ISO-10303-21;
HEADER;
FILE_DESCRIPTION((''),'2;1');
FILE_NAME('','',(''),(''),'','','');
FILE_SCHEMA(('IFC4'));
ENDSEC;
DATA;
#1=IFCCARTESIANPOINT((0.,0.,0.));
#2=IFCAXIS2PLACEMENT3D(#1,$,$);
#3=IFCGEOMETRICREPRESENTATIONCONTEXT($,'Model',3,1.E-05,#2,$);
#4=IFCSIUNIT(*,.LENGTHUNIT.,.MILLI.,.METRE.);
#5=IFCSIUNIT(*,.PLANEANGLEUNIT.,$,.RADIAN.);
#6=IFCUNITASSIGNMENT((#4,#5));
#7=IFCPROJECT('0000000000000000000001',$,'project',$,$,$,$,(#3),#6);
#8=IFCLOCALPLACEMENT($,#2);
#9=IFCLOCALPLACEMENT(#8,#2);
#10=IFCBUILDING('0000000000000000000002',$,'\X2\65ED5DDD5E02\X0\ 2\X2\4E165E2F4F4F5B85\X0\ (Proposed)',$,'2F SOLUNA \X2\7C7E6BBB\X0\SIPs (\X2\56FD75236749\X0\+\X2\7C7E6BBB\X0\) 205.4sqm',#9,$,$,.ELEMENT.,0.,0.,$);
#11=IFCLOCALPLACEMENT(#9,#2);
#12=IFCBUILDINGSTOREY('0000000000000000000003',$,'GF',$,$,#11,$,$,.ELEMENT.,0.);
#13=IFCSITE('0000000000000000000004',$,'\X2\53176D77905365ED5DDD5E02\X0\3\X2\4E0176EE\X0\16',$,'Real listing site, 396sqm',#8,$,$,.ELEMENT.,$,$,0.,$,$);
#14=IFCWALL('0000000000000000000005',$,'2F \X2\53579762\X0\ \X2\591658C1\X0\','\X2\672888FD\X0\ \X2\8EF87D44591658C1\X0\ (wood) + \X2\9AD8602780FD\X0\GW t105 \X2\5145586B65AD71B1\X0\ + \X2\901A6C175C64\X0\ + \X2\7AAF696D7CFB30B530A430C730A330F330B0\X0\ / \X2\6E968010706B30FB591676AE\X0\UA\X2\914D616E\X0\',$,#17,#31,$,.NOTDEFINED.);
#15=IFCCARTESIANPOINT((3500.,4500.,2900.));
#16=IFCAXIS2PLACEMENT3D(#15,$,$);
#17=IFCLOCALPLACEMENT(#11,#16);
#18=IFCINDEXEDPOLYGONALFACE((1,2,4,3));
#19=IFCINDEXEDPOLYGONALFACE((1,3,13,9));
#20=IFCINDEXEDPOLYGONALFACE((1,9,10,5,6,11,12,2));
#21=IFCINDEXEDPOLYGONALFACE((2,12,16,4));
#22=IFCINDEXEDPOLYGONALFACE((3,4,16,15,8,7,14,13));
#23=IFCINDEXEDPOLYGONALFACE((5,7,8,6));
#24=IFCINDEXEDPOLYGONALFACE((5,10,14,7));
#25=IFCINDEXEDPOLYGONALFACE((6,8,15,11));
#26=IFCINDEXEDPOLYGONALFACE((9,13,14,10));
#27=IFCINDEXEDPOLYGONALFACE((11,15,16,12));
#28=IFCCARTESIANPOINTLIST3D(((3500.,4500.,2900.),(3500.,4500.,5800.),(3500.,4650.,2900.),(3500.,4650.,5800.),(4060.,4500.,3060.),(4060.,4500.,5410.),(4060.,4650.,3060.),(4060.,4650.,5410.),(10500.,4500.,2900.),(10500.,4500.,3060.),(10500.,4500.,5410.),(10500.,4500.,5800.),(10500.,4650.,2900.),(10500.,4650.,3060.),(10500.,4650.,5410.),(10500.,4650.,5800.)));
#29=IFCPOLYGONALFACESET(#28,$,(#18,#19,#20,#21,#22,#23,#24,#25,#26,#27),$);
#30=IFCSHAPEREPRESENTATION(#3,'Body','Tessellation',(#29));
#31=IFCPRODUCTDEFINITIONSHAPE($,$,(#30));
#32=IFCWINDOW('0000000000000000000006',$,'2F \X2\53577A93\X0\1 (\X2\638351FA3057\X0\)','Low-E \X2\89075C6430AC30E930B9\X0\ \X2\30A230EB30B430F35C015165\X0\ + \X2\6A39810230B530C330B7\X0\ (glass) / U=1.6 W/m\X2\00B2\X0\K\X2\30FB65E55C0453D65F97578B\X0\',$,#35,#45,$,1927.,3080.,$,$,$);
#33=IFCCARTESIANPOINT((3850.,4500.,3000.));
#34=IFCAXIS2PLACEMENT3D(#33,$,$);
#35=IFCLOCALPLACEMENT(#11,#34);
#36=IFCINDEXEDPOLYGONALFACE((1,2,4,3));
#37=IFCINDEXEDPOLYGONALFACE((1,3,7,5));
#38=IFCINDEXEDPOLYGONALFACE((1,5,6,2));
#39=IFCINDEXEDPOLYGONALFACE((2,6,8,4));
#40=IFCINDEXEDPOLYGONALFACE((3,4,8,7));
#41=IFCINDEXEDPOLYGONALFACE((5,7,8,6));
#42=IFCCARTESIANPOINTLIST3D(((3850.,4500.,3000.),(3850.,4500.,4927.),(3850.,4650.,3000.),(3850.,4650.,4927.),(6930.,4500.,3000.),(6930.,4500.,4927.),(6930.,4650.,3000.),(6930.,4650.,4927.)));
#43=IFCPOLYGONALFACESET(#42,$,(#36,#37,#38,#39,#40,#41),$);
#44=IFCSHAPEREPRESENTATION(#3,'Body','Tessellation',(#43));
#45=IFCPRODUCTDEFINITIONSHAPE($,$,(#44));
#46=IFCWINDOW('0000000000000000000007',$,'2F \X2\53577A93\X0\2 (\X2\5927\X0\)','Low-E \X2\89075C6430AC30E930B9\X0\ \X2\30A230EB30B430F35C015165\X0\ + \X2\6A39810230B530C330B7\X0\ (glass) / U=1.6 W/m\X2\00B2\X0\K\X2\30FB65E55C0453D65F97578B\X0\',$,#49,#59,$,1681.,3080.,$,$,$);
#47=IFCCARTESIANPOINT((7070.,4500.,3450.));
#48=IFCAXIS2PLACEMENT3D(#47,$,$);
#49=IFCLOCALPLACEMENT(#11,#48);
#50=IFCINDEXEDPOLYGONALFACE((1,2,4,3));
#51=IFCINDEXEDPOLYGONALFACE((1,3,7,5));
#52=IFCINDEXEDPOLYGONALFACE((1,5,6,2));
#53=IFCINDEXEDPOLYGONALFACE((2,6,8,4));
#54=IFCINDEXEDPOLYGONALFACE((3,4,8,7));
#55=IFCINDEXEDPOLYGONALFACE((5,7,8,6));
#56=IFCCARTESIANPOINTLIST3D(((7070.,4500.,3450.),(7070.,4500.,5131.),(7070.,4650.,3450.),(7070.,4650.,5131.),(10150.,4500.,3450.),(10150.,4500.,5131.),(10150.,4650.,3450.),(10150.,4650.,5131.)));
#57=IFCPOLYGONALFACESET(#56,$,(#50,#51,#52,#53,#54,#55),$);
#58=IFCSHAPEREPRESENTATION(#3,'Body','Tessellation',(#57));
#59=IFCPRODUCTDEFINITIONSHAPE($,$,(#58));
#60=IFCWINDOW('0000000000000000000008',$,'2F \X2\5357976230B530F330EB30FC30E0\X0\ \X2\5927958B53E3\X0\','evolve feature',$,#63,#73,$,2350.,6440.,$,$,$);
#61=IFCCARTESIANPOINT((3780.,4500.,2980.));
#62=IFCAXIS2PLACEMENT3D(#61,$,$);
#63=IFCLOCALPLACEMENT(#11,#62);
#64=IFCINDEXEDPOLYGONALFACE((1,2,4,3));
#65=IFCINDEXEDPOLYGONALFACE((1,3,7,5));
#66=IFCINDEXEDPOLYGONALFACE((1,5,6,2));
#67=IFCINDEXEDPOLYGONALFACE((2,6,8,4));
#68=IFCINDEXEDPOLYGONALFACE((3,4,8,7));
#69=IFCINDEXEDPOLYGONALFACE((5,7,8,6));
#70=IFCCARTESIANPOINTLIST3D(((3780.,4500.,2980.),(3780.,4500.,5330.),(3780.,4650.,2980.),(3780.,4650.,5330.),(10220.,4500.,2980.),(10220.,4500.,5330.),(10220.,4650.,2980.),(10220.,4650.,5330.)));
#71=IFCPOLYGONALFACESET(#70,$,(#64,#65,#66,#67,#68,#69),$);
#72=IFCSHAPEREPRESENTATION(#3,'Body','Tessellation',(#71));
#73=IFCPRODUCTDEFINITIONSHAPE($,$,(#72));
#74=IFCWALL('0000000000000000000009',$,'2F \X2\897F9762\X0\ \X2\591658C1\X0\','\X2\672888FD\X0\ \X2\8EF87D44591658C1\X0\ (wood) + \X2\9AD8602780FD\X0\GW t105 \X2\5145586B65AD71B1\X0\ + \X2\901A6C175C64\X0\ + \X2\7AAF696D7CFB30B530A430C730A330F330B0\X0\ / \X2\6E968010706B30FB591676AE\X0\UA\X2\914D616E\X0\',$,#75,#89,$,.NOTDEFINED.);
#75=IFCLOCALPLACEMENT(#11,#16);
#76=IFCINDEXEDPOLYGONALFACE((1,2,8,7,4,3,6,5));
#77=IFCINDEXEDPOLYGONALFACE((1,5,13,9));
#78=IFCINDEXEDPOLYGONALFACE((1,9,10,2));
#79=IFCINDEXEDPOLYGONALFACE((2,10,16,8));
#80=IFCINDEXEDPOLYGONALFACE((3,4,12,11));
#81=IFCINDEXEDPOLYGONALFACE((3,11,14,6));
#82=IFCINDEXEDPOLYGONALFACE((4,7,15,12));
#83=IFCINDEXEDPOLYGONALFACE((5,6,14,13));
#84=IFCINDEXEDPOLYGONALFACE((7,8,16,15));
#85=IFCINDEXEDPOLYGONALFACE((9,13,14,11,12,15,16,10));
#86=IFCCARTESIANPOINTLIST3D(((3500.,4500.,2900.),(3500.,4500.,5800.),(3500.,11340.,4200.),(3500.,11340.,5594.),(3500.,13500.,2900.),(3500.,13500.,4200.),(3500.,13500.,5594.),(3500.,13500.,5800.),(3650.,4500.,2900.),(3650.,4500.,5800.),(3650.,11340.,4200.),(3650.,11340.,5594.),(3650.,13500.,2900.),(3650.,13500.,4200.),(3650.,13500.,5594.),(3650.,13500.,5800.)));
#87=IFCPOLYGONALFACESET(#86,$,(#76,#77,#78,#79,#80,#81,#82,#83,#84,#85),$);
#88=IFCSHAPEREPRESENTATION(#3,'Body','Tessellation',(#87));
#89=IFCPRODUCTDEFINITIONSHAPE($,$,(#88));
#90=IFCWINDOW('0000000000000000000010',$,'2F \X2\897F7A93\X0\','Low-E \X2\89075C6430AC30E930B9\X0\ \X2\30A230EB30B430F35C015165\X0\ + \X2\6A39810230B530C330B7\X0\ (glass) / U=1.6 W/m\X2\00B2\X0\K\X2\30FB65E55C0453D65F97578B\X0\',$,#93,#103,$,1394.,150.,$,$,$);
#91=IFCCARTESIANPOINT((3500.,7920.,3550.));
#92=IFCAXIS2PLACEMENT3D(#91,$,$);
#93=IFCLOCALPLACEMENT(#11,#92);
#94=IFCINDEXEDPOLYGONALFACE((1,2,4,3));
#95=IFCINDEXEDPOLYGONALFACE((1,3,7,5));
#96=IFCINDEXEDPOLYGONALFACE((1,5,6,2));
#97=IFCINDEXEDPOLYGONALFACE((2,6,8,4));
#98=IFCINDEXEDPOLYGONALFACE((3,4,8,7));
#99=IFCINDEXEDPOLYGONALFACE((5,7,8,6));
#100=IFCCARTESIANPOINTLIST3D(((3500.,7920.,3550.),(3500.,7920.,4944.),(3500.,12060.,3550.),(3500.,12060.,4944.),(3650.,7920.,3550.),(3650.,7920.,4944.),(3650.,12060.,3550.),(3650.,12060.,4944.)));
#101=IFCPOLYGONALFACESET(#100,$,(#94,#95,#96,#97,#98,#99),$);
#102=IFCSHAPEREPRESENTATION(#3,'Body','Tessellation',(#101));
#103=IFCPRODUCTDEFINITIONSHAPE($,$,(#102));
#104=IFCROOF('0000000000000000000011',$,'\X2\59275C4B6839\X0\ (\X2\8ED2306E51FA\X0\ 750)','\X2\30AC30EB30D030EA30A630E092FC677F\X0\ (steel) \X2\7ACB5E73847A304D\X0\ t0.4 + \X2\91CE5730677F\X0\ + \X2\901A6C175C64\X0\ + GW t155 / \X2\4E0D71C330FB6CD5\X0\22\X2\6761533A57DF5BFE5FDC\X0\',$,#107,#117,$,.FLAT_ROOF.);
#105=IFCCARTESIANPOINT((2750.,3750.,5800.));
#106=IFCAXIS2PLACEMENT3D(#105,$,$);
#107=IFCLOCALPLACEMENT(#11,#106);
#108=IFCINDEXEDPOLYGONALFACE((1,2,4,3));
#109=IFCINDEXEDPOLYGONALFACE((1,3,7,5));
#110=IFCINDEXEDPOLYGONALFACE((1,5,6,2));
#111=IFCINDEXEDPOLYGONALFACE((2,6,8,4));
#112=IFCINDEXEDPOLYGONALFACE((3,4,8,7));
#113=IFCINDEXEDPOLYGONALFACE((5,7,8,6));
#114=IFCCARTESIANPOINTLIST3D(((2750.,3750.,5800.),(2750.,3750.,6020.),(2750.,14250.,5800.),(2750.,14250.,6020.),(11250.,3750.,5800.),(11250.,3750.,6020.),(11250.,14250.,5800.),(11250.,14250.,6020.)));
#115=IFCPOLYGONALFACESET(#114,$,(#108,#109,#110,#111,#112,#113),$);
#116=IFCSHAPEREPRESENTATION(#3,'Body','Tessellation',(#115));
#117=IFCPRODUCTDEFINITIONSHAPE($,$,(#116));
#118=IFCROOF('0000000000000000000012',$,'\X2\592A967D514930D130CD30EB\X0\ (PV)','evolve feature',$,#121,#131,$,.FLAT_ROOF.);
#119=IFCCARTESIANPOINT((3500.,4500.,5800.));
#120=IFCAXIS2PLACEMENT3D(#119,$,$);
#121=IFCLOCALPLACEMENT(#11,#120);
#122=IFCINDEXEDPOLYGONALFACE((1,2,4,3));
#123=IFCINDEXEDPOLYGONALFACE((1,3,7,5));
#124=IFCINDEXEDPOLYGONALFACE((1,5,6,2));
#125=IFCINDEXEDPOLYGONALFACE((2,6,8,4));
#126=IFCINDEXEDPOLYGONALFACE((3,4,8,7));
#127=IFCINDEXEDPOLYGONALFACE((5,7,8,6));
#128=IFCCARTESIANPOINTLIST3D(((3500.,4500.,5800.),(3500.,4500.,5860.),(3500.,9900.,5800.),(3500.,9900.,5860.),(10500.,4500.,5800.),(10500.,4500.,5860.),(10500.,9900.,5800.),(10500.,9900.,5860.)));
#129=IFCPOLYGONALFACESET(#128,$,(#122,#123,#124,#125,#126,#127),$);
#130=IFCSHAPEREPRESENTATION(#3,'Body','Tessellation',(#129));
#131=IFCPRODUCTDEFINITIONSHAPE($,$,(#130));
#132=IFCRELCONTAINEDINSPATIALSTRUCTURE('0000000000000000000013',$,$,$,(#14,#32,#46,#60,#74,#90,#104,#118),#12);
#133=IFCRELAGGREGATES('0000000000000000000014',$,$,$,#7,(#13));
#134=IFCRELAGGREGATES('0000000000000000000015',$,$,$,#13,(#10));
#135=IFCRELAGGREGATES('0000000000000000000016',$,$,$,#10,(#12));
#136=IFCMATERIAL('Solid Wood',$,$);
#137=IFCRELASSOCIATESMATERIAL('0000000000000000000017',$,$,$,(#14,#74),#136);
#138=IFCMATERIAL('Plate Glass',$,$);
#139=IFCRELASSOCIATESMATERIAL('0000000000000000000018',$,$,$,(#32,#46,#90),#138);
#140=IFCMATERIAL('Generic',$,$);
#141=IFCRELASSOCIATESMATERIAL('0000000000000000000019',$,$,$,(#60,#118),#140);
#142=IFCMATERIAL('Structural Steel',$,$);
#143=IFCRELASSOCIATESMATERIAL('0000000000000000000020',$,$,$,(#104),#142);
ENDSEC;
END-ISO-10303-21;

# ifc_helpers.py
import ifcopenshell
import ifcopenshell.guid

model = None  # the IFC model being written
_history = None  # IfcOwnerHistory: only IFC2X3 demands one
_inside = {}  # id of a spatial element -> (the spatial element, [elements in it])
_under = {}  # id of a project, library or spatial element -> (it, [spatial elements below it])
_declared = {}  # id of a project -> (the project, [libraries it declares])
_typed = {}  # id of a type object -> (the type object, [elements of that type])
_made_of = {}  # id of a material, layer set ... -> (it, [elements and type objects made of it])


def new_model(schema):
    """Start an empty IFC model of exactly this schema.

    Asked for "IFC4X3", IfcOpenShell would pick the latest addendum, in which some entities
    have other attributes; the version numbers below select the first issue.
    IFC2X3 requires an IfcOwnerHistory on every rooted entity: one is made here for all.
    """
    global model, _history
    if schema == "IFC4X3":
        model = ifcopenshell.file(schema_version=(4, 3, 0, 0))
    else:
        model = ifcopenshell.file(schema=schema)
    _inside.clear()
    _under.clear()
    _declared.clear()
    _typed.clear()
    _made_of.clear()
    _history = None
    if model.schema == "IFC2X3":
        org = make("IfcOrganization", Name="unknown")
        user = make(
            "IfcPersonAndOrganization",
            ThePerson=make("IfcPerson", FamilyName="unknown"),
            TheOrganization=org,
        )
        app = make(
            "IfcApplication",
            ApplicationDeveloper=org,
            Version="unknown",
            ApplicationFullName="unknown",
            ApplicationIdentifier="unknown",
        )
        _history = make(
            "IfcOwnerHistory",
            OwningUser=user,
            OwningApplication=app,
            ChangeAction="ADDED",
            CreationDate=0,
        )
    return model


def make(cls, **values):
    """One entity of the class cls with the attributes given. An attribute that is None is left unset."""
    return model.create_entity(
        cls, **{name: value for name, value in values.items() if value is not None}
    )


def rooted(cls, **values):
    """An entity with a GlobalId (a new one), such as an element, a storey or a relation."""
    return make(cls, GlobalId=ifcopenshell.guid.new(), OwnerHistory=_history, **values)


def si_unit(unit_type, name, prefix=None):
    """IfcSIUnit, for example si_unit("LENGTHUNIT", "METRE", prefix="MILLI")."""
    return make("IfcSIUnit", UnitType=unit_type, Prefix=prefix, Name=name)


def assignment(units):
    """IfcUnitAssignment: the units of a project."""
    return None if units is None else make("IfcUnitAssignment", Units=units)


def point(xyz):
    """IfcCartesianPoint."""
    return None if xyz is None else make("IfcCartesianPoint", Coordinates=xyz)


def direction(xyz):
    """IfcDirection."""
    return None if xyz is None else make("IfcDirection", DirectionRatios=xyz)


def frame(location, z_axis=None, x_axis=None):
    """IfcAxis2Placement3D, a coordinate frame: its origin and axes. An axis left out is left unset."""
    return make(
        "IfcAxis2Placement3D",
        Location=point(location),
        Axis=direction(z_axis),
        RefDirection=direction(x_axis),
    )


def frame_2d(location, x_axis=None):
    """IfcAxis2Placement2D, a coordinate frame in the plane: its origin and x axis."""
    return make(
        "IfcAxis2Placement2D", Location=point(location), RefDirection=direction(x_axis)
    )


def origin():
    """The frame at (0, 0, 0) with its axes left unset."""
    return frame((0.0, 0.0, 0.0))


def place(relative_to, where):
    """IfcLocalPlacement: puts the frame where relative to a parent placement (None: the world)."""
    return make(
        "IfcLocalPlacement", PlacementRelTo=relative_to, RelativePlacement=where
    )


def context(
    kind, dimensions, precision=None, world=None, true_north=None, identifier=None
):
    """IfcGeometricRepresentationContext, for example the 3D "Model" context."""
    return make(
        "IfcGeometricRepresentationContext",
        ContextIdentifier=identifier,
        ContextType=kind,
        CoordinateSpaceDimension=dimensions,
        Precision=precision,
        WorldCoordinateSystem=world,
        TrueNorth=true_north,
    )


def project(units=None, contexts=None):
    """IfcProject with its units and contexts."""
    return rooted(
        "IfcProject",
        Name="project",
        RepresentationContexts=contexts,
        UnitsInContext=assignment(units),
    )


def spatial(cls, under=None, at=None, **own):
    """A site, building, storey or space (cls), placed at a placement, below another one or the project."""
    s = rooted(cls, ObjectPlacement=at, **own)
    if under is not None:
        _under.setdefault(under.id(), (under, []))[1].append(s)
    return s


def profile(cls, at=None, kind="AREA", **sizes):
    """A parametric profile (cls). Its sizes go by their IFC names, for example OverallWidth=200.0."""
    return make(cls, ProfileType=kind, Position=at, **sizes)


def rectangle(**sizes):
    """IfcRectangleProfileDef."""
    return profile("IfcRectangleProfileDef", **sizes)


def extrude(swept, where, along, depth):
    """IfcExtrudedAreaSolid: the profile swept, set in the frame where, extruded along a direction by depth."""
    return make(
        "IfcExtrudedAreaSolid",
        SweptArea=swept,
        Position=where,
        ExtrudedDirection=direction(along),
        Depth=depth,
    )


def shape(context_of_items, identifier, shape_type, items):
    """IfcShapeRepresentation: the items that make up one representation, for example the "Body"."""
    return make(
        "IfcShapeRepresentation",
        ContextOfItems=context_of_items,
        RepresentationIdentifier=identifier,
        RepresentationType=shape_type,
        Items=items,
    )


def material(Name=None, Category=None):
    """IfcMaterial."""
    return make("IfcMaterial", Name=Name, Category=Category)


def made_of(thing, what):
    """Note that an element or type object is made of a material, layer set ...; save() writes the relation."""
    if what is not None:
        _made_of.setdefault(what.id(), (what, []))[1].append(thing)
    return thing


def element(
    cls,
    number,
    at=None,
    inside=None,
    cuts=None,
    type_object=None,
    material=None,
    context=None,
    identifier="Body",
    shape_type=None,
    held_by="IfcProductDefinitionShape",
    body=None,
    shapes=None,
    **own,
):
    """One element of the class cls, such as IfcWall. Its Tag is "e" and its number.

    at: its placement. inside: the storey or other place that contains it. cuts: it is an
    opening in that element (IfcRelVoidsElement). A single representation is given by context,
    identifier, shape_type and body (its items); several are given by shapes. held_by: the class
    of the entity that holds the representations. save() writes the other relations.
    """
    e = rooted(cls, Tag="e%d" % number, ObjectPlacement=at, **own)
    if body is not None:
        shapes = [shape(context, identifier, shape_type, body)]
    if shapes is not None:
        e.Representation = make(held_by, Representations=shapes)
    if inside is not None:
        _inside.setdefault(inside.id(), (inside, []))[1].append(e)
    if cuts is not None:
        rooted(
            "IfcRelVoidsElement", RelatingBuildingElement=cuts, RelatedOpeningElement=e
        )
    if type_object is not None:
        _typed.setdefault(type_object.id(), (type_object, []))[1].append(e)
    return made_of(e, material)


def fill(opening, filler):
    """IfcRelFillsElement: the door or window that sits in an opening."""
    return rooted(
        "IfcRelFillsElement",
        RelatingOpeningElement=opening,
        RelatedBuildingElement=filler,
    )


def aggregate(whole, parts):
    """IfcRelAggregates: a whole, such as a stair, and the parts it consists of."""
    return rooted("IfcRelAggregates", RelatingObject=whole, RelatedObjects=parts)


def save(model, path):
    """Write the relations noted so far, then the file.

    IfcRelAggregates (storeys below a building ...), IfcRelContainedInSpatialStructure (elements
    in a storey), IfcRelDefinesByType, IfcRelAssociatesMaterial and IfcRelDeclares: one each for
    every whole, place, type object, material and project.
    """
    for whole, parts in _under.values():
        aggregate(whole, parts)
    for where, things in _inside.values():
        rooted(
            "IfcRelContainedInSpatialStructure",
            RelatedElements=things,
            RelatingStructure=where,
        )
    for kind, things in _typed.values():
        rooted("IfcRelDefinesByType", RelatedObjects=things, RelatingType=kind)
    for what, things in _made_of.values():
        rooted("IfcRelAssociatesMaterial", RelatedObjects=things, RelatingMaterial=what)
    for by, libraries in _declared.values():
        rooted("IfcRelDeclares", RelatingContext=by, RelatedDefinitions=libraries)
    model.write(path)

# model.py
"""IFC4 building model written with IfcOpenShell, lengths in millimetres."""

from ifc_helpers import new_model, si_unit, frame, frame_2d, origin, place, context, project, spatial, rectangle, extrude, material, element, fill, save


model = new_model("IFC4")

# Units and contexts
model_context = context("Model", 3, precision=1e-05, world=origin())
ifc_project = project(units=[si_unit("LENGTHUNIT", "METRE", prefix="MILLI"), si_unit("PLANEANGLEUNIT", "RADIAN")], contexts=[model_context])

# Site, building, storey
site_placement = place(None, origin())
site = spatial("IfcSite", under=ifc_project, at=site_placement, Name="北海道旭川市3丁目16", ObjectType="Real listing site, 396sqm", CompositionType="ELEMENT", RefElevation=0.0)
building_placement = place(site_placement, origin())
building = spatial("IfcBuilding", under=site, at=building_placement, Name="旭川市 2世帯住宅 (Proposed)", ObjectType="2F SOLUNA 籾殻SIPs (国産杉+籾殻) 205.4sqm", CompositionType="ELEMENT", ElevationOfRefHeight=0.0, ElevationOfTerrain=0.0)
storey_placement = place(building_placement, origin())
storey = spatial("IfcBuildingStorey", under=building, at=storey_placement, Name="GF", CompositionType="ELEMENT", Elevation=0.0)

# Shared definitions
ifc_material_1 = material(Name="Solid Wood")
ifc_material_2 = material(Name="Generic")

# Shared definitions
ifc_material_3 = material(Name="Plate Glass")

# Wall, openings, windows
wall_1_placement = place(storey_placement, frame((3500.0, 4500.0, 2900.0)))
wall_1 = element("IfcWall", 1, at=wall_1_placement, inside=storey, material=ifc_material_1, Name="2F 南面 外壁", Description="木製 軸組外壁 (wood) + 高性能GW t105 充填断熱 + 通気層 + 窯業系サイディング / 準耐火・外皮UA配慮", PredefinedType="NOTDEFINED", context=model_context, shape_type="SweptSolid", body=[
    extrude(rectangle(XDim=7000.0, YDim=150.0, at=frame_2d((3500.0, 75.0))), frame((3500.0, 4500.0, 2900.0)), (0.0, 0.0, 1.0), 2900.0),
])
opening_1_placement = place(storey_placement, frame((3850.0, 4500.0, 3000.0)))
opening_1 = element("IfcOpeningElement", 2, at=opening_1_placement, cuts=wall_1, PredefinedType="NOTDEFINED", context=model_context, shape_type="SweptSolid", body=[
    extrude(rectangle(XDim=3080.0, YDim=150.0, at=frame_2d((1540.0, 75.0))), frame((3850.0, 4500.0, 3000.0)), (0.0, 0.0, 1.0), 1927.0),
])
opening_2_placement = place(storey_placement, frame((7070.0, 4500.0, 3450.0)))
opening_2 = element("IfcOpeningElement", 3, at=opening_2_placement, cuts=wall_1, PredefinedType="NOTDEFINED", context=model_context, shape_type="SweptSolid", body=[
    extrude(rectangle(XDim=3080.0, YDim=150.0, at=frame_2d((1540.0, 75.0))), frame((7070.0, 4500.0, 3450.0)), (0.0, 0.0, 1.0), 1681.0),
])
opening_3_placement = place(storey_placement, frame((3780.0, 4500.0, 2980.0)))
opening_3 = element("IfcOpeningElement", 4, at=opening_3_placement, cuts=wall_1, PredefinedType="NOTDEFINED", context=model_context, shape_type="SweptSolid", body=[
    extrude(rectangle(XDim=6440.0, YDim=150.0, at=frame_2d((3220.0, 75.0))), frame((3780.0, 4500.0, 2980.0)), (0.0, 0.0, 1.0), 2350.0),
])
window_1_placement = place(storey_placement, frame((3850.0, 4500.0, 3000.0)))
window_1 = element("IfcWindow", 5, at=window_1_placement, inside=storey, material=ifc_material_3, Name="2F 南窓1 (掃出し)", Description="Low-E 複層ガラス アルゴン封入 + 樹脂サッシ (glass) / U=1.6 W/m²K・日射取得型", OverallHeight=1927.0, OverallWidth=3080.0, context=model_context, shape_type="SweptSolid", body=[
    extrude(rectangle(XDim=3080.0, YDim=150.0, at=frame_2d((1540.0, 75.0))), frame((3850.0, 4500.0, 3000.0)), (0.0, 0.0, 1.0), 1927.0),
])
fill(opening_1, window_1)
window_2_placement = place(storey_placement, frame((7070.0, 4500.0, 3450.0)))
window_2 = element("IfcWindow", 6, at=window_2_placement, inside=storey, material=ifc_material_3, Name="2F 南窓2 (大)", Description="Low-E 複層ガラス アルゴン封入 + 樹脂サッシ (glass) / U=1.6 W/m²K・日射取得型", OverallHeight=1681.0, OverallWidth=3080.0, context=model_context, shape_type="SweptSolid", body=[
    extrude(rectangle(XDim=3080.0, YDim=150.0, at=frame_2d((1540.0, 75.0))), frame((7070.0, 4500.0, 3450.0)), (0.0, 0.0, 1.0), 1681.0),
])
fill(opening_2, window_2)
window_3_placement = place(storey_placement, frame((3780.0, 4500.0, 2980.0)))
window_3 = element("IfcWindow", 7, at=window_3_placement, inside=storey, material=ifc_material_2, Name="2F 南面サンルーム 大開口", Description="evolve feature", OverallHeight=2350.0, OverallWidth=6440.0, context=model_context, shape_type="SweptSolid", body=[
    extrude(rectangle(XDim=6440.0, YDim=150.0, at=frame_2d((3220.0, 75.0))), frame((3780.0, 4500.0, 2980.0)), (0.0, 0.0, 1.0), 2350.0),
])
fill(opening_3, window_3)

# Wall, opening, window
wall_2_placement = place(storey_placement, frame((3500.0, 4500.0, 2900.0)))
wall_2 = element("IfcWall", 8, at=wall_2_placement, inside=storey, material=ifc_material_1, Name="2F 西面 外壁", Description="木製 軸組外壁 (wood) + 高性能GW t105 充填断熱 + 通気層 + 窯業系サイディング / 準耐火・外皮UA配慮", PredefinedType="NOTDEFINED", context=model_context, shape_type="SweptSolid", body=[
    extrude(rectangle(XDim=150.0, YDim=9000.0, at=frame_2d((75.0, 4500.0))), frame((3500.0, 4500.0, 2900.0)), (0.0, 0.0, 1.0), 2900.0),
])
opening_4_placement = place(storey_placement, frame((3500.0, 7920.0, 3550.0)))
opening_4 = element("IfcOpeningElement", 9, at=opening_4_placement, cuts=wall_2, PredefinedType="NOTDEFINED", context=model_context, shape_type="SweptSolid", body=[
    extrude(rectangle(XDim=150.0, YDim=4140.0, at=frame_2d((75.0, 2070.0))), frame((3500.0, 7920.0, 3550.0)), (0.0, 0.0, 1.0), 1394.0),
])
window_4_placement = place(storey_placement, frame((3500.0, 7920.0, 3550.0)))
window_4 = element("IfcWindow", 10, at=window_4_placement, inside=storey, material=ifc_material_3, Name="2F 西窓", Description="Low-E 複層ガラス アルゴン封入 + 樹脂サッシ (glass) / U=1.6 W/m²K・日射取得型", OverallHeight=1394.0, OverallWidth=150.0, context=model_context, shape_type="SweptSolid", body=[
    extrude(rectangle(XDim=150.0, YDim=4140.0, at=frame_2d((75.0, 2070.0))), frame((3500.0, 7920.0, 3550.0)), (0.0, 0.0, 1.0), 1394.0),
])
fill(opening_4, window_4)

# Roofs
ifc_material_4 = material(Name="Structural Steel")
roof_1_placement = place(storey_placement, frame((2750.0, 3750.0, 5800.0)))
element("IfcRoof", 11, at=roof_1_placement, inside=storey, material=ifc_material_4, Name="大屋根 (軒の出 750)", Description="ガルバリウム鋼板 (steel) 立平葺き t0.4 + 野地板 + 通気層 + GW t155 / 不燃・法22条区域対応", PredefinedType="FLAT_ROOF", context=model_context, shape_type="SweptSolid", body=[
    extrude(rectangle(XDim=8500.0, YDim=10500.0, at=frame_2d((4250.0, 5250.0))), frame((2750.0, 3750.0, 5800.0)), (0.0, 0.0, 1.0), 220.0),
])
roof_2_placement = place(storey_placement, frame((3500.0, 4500.0, 5800.0)))
element("IfcRoof", 12, at=roof_2_placement, inside=storey, material=ifc_material_2, Name="太陽光パネル (PV)", Description="evolve feature", PredefinedType="FLAT_ROOF", context=model_context, shape_type="SweptSolid", body=[
    extrude(rectangle(XDim=7000.0, YDim=5400.0, at=frame_2d((3500.0, 2700.0))), frame((3500.0, 4500.0, 5800.0)), (0.0, 0.0, 1.0), 60.0),
])

save(model, "model.ifc")
